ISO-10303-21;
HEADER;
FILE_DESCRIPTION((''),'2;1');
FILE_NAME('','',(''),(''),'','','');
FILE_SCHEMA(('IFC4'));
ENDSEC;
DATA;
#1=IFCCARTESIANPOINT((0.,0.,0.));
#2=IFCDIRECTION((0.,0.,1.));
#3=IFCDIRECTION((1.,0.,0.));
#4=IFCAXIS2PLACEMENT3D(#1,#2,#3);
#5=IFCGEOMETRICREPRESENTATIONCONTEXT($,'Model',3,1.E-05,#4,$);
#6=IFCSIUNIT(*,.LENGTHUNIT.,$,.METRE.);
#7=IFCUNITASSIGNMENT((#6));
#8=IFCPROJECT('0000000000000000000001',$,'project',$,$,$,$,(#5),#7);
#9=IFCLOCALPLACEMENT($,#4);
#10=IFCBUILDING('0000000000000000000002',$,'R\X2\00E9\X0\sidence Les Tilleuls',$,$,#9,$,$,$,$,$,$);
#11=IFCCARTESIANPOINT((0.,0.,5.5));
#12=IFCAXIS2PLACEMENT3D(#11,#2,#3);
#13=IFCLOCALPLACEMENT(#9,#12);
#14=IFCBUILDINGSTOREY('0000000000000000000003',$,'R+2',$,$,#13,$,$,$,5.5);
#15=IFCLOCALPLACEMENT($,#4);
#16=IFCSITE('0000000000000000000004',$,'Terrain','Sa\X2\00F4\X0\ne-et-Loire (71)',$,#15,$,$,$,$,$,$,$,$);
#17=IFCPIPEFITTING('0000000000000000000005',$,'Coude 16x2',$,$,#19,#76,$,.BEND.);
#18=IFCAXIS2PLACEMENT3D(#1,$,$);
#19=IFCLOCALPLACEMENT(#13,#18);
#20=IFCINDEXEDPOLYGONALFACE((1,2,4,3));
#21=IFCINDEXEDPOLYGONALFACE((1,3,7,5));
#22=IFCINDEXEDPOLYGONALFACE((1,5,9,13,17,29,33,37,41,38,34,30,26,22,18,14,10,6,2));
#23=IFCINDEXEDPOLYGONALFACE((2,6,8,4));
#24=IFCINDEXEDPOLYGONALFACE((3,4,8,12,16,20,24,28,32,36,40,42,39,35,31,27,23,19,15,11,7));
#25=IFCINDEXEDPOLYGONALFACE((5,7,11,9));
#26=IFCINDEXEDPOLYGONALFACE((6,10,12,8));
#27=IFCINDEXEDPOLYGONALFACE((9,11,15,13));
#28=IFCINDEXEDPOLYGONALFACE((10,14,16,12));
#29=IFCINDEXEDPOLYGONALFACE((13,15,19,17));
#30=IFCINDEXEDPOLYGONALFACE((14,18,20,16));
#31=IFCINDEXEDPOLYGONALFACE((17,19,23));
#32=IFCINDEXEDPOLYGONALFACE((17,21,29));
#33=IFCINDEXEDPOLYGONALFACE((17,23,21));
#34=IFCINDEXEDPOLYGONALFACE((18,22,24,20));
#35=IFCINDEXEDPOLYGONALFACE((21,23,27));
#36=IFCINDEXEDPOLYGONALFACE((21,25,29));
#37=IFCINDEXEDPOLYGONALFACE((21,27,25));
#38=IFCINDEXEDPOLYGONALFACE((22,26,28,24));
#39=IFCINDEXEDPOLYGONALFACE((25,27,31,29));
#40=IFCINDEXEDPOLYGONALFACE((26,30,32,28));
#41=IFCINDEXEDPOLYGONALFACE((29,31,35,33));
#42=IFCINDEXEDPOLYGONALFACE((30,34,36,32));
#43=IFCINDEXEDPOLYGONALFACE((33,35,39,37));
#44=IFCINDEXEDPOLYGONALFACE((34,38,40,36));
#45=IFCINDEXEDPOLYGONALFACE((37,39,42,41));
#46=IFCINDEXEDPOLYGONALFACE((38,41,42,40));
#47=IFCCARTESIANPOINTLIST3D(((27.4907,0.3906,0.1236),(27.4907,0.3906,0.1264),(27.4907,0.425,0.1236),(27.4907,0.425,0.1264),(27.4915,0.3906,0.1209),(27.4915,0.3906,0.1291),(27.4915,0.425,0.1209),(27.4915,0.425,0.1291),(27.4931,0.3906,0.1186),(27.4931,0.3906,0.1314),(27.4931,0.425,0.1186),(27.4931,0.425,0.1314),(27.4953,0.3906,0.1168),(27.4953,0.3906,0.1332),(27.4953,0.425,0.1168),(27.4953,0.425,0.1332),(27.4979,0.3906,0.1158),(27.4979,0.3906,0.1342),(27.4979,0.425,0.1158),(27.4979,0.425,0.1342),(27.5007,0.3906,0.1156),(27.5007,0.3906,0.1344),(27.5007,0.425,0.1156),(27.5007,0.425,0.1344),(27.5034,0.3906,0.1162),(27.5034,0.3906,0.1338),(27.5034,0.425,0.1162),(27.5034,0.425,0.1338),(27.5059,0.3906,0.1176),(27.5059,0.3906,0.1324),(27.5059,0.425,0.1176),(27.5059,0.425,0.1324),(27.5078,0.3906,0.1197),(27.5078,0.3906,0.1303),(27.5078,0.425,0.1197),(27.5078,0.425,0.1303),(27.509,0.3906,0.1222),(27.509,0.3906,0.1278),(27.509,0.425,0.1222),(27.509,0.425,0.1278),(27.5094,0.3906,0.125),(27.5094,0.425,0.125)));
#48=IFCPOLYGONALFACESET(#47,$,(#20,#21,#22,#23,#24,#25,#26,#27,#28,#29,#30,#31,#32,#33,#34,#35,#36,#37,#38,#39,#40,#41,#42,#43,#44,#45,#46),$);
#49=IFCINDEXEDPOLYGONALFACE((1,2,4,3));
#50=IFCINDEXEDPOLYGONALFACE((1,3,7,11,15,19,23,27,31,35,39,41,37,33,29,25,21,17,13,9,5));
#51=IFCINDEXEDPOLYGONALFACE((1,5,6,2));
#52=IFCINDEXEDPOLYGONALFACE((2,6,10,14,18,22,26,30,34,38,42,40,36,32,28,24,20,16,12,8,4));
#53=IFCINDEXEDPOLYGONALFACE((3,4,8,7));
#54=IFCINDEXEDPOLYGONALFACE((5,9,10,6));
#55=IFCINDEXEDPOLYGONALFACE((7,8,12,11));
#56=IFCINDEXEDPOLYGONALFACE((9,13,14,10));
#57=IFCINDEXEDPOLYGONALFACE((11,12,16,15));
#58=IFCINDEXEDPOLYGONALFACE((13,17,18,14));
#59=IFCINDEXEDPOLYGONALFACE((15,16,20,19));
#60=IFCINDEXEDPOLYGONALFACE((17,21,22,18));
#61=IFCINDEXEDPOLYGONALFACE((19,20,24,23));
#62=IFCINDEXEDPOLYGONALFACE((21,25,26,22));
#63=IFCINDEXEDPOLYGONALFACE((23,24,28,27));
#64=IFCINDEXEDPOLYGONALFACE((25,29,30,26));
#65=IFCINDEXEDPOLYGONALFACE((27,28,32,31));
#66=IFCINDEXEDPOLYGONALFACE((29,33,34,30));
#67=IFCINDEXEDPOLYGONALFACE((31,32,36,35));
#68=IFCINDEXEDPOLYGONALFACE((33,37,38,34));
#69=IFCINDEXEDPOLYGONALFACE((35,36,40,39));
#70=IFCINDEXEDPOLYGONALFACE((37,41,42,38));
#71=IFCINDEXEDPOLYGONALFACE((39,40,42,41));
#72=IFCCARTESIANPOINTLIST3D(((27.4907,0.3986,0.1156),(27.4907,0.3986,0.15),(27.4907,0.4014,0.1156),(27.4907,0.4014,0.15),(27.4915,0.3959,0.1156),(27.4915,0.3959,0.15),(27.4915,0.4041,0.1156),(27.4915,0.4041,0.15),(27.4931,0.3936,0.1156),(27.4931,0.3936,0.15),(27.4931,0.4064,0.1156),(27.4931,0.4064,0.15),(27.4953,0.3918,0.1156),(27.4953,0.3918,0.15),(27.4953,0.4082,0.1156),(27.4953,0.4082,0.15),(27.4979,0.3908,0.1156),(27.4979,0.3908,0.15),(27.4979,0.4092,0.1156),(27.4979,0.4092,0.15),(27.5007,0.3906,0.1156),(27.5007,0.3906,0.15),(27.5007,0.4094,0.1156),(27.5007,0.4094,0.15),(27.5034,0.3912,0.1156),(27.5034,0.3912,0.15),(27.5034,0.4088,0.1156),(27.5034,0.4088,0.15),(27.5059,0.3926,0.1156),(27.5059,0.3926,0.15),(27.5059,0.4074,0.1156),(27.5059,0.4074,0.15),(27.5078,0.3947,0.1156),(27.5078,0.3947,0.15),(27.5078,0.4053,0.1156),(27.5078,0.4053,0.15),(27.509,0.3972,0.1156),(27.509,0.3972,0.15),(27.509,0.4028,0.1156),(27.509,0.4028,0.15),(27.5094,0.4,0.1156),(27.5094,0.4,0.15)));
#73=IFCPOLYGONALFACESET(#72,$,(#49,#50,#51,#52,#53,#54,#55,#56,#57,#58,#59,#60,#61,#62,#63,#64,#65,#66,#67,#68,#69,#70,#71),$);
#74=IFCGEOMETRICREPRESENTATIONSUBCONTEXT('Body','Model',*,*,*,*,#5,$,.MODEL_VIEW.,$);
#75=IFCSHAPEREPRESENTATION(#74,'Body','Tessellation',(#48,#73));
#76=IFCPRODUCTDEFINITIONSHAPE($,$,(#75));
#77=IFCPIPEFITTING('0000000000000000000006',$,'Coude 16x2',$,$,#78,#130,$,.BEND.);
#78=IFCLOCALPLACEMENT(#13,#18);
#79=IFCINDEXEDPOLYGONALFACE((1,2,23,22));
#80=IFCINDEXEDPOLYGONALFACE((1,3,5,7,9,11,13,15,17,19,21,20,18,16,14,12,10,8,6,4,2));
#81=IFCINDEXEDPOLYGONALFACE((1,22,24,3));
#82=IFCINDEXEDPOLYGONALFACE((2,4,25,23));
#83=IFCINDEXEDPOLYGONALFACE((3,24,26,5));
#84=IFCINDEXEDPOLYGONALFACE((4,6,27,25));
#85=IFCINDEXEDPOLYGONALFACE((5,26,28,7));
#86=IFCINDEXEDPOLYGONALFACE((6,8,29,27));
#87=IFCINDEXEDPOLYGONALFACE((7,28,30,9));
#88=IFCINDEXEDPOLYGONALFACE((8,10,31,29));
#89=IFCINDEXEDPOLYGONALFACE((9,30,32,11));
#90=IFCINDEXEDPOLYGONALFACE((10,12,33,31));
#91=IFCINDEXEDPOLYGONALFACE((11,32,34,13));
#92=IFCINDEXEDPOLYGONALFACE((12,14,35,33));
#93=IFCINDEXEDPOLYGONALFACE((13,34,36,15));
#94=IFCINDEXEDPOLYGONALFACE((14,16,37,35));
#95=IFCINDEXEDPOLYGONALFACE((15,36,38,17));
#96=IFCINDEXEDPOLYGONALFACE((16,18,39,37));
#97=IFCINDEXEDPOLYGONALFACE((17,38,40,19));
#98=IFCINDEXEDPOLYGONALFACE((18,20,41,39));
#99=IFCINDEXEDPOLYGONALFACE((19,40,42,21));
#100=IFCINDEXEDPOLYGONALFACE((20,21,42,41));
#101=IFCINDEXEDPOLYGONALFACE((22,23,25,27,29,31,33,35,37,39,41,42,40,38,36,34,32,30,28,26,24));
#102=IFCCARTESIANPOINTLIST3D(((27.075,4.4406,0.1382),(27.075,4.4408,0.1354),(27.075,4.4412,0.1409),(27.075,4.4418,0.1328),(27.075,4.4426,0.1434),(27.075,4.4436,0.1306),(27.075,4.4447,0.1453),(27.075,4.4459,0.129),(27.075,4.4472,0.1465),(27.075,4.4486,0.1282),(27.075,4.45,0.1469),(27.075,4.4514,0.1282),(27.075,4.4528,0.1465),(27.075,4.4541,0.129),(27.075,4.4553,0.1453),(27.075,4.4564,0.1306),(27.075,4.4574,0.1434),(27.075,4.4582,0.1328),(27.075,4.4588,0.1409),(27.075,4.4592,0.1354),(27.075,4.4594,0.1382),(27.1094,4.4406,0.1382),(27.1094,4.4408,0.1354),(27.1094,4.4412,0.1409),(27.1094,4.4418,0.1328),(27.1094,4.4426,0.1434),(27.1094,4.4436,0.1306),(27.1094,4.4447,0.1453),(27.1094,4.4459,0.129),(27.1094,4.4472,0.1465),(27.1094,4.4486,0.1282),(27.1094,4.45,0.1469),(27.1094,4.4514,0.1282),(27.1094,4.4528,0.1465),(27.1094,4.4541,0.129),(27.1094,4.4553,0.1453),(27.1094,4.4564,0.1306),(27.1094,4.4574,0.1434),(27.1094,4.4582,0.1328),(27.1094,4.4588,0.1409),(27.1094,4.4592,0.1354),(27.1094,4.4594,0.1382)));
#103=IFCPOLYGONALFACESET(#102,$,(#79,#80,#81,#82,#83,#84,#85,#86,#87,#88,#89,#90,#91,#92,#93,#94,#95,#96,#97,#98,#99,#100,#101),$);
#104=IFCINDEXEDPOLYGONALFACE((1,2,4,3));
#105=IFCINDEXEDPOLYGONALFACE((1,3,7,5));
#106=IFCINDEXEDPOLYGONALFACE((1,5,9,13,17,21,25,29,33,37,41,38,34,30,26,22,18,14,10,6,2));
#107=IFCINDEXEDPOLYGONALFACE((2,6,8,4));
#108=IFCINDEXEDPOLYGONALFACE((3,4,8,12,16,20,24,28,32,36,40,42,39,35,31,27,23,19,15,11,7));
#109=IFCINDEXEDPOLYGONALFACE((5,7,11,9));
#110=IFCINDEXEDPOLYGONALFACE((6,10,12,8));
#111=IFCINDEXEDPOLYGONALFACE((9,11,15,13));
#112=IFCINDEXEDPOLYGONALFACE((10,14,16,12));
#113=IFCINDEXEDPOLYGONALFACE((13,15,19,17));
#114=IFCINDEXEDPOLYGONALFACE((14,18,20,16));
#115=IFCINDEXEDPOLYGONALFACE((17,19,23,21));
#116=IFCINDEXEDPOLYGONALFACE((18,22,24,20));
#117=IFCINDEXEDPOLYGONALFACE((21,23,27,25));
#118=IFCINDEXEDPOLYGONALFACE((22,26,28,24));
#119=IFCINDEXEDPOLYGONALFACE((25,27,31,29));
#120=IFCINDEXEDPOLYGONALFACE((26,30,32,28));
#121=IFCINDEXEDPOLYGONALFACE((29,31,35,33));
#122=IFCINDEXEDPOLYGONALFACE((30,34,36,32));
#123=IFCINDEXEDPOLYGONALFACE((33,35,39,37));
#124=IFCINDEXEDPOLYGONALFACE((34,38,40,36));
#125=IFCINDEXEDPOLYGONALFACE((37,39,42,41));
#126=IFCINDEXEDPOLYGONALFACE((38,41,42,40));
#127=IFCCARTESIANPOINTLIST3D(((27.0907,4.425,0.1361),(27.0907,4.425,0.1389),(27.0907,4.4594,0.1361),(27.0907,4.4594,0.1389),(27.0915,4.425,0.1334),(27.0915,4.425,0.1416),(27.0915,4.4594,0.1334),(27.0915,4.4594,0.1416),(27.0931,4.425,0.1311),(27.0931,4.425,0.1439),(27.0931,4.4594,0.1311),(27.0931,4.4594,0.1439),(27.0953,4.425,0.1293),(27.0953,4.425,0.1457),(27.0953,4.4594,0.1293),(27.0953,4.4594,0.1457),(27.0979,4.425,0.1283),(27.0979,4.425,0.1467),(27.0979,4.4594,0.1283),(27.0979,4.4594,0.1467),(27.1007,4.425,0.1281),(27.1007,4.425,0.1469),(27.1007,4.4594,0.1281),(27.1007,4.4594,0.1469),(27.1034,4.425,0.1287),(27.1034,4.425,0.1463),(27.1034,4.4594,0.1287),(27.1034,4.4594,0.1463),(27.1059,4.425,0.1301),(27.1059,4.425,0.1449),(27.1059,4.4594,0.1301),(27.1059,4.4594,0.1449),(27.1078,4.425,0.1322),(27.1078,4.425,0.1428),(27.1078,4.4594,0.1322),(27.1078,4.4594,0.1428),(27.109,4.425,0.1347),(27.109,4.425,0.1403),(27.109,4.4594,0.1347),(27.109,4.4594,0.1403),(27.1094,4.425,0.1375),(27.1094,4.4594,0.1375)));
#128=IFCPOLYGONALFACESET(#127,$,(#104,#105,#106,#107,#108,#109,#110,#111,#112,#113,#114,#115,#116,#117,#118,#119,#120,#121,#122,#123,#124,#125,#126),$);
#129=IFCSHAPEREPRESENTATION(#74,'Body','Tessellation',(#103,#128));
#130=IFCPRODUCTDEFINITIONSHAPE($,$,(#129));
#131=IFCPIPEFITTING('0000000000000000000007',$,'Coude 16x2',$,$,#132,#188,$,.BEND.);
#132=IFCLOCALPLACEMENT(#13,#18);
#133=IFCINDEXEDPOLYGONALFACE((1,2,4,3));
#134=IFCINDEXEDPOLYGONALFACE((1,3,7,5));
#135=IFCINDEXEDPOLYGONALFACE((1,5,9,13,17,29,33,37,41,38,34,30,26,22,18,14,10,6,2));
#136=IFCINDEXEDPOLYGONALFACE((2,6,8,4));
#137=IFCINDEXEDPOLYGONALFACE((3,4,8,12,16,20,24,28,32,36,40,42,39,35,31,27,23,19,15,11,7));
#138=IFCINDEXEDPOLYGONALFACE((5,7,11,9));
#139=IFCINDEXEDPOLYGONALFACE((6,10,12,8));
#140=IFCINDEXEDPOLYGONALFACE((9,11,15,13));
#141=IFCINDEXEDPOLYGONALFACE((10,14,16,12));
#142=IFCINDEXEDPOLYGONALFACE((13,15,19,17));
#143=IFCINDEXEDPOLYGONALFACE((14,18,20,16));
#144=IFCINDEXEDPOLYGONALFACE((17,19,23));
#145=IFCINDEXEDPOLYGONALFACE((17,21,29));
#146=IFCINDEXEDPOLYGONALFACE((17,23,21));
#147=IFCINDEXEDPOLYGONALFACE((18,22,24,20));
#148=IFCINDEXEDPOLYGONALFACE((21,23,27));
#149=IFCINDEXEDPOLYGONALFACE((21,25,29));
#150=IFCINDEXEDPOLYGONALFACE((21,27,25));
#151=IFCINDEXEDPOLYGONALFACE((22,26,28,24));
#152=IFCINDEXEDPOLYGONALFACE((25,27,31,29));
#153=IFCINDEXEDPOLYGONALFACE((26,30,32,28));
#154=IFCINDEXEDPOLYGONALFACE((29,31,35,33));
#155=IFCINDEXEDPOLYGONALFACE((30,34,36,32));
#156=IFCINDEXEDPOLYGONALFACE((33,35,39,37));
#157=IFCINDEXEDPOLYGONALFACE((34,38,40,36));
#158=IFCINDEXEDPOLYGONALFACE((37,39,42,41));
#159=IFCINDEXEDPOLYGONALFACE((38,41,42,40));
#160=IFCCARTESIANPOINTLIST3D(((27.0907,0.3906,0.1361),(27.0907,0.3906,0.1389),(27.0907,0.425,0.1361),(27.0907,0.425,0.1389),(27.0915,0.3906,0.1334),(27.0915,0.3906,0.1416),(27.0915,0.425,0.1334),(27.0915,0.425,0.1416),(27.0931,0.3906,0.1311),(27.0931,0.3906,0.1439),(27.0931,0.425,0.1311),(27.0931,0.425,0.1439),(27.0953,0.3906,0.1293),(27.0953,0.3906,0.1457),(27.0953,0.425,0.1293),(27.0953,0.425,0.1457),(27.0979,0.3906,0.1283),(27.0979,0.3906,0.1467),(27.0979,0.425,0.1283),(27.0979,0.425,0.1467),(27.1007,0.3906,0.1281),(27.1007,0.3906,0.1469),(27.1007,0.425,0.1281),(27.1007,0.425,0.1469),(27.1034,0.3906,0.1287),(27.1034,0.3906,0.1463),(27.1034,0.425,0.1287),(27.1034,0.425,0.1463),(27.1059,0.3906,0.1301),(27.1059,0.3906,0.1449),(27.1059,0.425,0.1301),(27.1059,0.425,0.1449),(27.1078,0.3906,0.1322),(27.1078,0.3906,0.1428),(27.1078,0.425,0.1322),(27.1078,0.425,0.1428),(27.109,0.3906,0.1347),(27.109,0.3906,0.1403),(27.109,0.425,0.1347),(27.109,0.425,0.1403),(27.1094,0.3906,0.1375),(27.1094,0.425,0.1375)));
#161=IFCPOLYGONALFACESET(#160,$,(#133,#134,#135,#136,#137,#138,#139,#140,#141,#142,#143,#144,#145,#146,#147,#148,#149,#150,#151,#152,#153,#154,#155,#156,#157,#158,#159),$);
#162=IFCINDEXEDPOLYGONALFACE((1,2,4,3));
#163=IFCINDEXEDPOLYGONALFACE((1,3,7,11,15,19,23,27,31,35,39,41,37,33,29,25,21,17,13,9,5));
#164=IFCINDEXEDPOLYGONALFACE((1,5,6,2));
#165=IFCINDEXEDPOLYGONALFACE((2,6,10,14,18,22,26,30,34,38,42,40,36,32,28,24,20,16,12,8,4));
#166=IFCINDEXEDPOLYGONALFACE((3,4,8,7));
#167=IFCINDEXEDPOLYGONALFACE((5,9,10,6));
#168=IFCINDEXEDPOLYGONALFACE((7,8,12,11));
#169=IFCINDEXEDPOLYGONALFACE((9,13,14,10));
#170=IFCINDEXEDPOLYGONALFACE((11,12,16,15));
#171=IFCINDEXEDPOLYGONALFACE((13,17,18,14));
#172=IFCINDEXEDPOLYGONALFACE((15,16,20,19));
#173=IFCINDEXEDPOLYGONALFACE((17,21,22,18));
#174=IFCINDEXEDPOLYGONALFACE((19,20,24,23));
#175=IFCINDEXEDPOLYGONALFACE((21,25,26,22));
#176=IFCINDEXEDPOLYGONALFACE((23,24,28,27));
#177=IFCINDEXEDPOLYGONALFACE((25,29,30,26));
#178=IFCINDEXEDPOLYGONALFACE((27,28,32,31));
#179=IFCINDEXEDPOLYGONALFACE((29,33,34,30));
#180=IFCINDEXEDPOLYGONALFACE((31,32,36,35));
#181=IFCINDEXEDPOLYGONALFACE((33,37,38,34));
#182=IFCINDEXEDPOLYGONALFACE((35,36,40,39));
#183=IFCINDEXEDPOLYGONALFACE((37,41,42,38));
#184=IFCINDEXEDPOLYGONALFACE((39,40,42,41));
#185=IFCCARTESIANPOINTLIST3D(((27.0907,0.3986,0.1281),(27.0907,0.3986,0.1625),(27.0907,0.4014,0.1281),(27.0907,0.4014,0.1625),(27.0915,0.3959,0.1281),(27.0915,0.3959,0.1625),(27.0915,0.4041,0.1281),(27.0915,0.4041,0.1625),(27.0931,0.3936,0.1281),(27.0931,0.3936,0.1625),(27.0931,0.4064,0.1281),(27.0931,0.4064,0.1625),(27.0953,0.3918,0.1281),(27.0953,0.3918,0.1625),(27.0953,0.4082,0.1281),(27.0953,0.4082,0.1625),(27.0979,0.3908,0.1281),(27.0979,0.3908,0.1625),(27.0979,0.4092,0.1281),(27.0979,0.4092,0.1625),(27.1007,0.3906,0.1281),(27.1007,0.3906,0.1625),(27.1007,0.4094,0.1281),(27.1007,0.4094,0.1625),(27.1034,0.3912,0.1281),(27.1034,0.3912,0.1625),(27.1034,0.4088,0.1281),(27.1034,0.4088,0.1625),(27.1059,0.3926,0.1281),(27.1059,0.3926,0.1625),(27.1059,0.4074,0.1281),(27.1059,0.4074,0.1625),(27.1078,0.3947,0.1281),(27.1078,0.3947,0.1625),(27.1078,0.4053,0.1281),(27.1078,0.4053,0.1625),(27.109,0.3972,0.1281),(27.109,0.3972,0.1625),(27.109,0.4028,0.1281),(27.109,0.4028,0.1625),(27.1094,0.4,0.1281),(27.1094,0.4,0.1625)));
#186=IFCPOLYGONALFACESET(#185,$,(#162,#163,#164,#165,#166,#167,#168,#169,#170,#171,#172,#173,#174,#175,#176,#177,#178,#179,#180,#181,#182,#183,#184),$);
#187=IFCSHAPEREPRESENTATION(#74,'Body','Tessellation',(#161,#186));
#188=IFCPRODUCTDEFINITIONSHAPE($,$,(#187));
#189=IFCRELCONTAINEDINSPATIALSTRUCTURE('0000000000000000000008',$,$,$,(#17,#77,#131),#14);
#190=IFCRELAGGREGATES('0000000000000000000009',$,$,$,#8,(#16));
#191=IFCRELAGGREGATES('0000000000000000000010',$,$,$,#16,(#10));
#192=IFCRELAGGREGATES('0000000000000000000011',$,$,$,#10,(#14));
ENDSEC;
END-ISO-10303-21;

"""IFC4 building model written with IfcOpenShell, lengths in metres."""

from ifc_helpers import new_model, si_unit, frame, origin_with_axes, place, context, subcontext, project, spatial, circle, extrude, element, save


model = new_model("IFC4")

# Units and contexts
model_context = context("Model", 3, precision=1e-05, world=origin_with_axes())
body_context = subcontext(model_context, "Body", "Model", "MODEL_VIEW")
ifc_project = project(units=[si_unit("LENGTHUNIT", "METRE")], contexts=[model_context])

# Site, building, storey
site_placement = place(None, origin_with_axes())
site = spatial("IfcSite", under=ifc_project, at=site_placement, Name="Terrain", Description="Saône-et-Loire (71)")
building_placement = place(None, origin_with_axes())
building = spatial("IfcBuilding", under=site, at=building_placement, Name="Résidence Les Tilleuls")
storey_placement = place(building_placement, frame((0.0, 0.0, 5.5), z_axis=(0.0, 0.0, 1.0), x_axis=(1.0, 0.0, 0.0)))
storey = spatial("IfcBuildingStorey", under=building, at=storey_placement, Name="R+2", Elevation=5.5)

# Pipe fittings
pipe_fitting_1_placement = place(storey_placement, frame((27.5, 0.4, 0.125), z_axis=(0.0, 0.0, 1.0), x_axis=(1.0, 0.0, 0.0)))
element("IfcPipeFitting", 1, at=pipe_fitting_1_placement, inside=storey, Name="Coude 16x2", PredefinedType="BEND", context=body_context, shape_type="SweptSolid", body=[
    extrude(circle(Radius=0.0094), frame((0.0, -0.0094, 0.0), z_axis=(0.0, 1.0, 0.0), x_axis=(1.0, 0.0, 0.0)), (0.0, 0.0, 1.0), 0.0344),
    extrude(circle(Radius=0.0094), frame((0.0, 0.0, -0.0094), z_axis=(0.0, 0.0, 1.0), x_axis=(1.0, 0.0, 0.0)), (0.0, 0.0, 1.0), 0.0344),
])
pipe_fitting_2_placement = place(storey_placement, frame((27.1, 4.45, 0.1375), z_axis=(0.0, 0.0, 1.0), x_axis=(1.0, 0.0, 0.0)))
element("IfcPipeFitting", 2, at=pipe_fitting_2_placement, inside=storey, Name="Coude 16x2", PredefinedType="BEND", context=body_context, shape_type="SweptSolid", body=[
    extrude(circle(Radius=0.0094), frame((0.0094, 0.0, 0.0), z_axis=(-1.0, 0.0, 0.0), x_axis=(0.0, 0.0, 1.0)), (0.0, 0.0, 1.0), 0.0344),
    extrude(circle(Radius=0.0094), frame((0.0, 0.0094, 0.0), z_axis=(0.0, -1.0, 0.0), x_axis=(1.0, 0.0, 0.0)), (0.0, 0.0, 1.0), 0.0344),
])
pipe_fitting_3_placement = place(storey_placement, frame((27.1, 0.4, 0.1375), z_axis=(0.0, 0.0, 1.0), x_axis=(1.0, 0.0, 0.0)))
element("IfcPipeFitting", 3, at=pipe_fitting_3_placement, inside=storey, Name="Coude 16x2", PredefinedType="BEND", context=body_context, shape_type="SweptSolid", body=[
    extrude(circle(Radius=0.0094), frame((0.0, -0.0094, 0.0), z_axis=(0.0, 1.0, 0.0), x_axis=(1.0, 0.0, 0.0)), (0.0, 0.0, 1.0), 0.0344),
    extrude(circle(Radius=0.0094), frame((0.0, 0.0, -0.0094), z_axis=(0.0, 0.0, 1.0), x_axis=(1.0, 0.0, 0.0)), (0.0, 0.0, 1.0), 0.0344),
])

save(model, "model.ifc")
